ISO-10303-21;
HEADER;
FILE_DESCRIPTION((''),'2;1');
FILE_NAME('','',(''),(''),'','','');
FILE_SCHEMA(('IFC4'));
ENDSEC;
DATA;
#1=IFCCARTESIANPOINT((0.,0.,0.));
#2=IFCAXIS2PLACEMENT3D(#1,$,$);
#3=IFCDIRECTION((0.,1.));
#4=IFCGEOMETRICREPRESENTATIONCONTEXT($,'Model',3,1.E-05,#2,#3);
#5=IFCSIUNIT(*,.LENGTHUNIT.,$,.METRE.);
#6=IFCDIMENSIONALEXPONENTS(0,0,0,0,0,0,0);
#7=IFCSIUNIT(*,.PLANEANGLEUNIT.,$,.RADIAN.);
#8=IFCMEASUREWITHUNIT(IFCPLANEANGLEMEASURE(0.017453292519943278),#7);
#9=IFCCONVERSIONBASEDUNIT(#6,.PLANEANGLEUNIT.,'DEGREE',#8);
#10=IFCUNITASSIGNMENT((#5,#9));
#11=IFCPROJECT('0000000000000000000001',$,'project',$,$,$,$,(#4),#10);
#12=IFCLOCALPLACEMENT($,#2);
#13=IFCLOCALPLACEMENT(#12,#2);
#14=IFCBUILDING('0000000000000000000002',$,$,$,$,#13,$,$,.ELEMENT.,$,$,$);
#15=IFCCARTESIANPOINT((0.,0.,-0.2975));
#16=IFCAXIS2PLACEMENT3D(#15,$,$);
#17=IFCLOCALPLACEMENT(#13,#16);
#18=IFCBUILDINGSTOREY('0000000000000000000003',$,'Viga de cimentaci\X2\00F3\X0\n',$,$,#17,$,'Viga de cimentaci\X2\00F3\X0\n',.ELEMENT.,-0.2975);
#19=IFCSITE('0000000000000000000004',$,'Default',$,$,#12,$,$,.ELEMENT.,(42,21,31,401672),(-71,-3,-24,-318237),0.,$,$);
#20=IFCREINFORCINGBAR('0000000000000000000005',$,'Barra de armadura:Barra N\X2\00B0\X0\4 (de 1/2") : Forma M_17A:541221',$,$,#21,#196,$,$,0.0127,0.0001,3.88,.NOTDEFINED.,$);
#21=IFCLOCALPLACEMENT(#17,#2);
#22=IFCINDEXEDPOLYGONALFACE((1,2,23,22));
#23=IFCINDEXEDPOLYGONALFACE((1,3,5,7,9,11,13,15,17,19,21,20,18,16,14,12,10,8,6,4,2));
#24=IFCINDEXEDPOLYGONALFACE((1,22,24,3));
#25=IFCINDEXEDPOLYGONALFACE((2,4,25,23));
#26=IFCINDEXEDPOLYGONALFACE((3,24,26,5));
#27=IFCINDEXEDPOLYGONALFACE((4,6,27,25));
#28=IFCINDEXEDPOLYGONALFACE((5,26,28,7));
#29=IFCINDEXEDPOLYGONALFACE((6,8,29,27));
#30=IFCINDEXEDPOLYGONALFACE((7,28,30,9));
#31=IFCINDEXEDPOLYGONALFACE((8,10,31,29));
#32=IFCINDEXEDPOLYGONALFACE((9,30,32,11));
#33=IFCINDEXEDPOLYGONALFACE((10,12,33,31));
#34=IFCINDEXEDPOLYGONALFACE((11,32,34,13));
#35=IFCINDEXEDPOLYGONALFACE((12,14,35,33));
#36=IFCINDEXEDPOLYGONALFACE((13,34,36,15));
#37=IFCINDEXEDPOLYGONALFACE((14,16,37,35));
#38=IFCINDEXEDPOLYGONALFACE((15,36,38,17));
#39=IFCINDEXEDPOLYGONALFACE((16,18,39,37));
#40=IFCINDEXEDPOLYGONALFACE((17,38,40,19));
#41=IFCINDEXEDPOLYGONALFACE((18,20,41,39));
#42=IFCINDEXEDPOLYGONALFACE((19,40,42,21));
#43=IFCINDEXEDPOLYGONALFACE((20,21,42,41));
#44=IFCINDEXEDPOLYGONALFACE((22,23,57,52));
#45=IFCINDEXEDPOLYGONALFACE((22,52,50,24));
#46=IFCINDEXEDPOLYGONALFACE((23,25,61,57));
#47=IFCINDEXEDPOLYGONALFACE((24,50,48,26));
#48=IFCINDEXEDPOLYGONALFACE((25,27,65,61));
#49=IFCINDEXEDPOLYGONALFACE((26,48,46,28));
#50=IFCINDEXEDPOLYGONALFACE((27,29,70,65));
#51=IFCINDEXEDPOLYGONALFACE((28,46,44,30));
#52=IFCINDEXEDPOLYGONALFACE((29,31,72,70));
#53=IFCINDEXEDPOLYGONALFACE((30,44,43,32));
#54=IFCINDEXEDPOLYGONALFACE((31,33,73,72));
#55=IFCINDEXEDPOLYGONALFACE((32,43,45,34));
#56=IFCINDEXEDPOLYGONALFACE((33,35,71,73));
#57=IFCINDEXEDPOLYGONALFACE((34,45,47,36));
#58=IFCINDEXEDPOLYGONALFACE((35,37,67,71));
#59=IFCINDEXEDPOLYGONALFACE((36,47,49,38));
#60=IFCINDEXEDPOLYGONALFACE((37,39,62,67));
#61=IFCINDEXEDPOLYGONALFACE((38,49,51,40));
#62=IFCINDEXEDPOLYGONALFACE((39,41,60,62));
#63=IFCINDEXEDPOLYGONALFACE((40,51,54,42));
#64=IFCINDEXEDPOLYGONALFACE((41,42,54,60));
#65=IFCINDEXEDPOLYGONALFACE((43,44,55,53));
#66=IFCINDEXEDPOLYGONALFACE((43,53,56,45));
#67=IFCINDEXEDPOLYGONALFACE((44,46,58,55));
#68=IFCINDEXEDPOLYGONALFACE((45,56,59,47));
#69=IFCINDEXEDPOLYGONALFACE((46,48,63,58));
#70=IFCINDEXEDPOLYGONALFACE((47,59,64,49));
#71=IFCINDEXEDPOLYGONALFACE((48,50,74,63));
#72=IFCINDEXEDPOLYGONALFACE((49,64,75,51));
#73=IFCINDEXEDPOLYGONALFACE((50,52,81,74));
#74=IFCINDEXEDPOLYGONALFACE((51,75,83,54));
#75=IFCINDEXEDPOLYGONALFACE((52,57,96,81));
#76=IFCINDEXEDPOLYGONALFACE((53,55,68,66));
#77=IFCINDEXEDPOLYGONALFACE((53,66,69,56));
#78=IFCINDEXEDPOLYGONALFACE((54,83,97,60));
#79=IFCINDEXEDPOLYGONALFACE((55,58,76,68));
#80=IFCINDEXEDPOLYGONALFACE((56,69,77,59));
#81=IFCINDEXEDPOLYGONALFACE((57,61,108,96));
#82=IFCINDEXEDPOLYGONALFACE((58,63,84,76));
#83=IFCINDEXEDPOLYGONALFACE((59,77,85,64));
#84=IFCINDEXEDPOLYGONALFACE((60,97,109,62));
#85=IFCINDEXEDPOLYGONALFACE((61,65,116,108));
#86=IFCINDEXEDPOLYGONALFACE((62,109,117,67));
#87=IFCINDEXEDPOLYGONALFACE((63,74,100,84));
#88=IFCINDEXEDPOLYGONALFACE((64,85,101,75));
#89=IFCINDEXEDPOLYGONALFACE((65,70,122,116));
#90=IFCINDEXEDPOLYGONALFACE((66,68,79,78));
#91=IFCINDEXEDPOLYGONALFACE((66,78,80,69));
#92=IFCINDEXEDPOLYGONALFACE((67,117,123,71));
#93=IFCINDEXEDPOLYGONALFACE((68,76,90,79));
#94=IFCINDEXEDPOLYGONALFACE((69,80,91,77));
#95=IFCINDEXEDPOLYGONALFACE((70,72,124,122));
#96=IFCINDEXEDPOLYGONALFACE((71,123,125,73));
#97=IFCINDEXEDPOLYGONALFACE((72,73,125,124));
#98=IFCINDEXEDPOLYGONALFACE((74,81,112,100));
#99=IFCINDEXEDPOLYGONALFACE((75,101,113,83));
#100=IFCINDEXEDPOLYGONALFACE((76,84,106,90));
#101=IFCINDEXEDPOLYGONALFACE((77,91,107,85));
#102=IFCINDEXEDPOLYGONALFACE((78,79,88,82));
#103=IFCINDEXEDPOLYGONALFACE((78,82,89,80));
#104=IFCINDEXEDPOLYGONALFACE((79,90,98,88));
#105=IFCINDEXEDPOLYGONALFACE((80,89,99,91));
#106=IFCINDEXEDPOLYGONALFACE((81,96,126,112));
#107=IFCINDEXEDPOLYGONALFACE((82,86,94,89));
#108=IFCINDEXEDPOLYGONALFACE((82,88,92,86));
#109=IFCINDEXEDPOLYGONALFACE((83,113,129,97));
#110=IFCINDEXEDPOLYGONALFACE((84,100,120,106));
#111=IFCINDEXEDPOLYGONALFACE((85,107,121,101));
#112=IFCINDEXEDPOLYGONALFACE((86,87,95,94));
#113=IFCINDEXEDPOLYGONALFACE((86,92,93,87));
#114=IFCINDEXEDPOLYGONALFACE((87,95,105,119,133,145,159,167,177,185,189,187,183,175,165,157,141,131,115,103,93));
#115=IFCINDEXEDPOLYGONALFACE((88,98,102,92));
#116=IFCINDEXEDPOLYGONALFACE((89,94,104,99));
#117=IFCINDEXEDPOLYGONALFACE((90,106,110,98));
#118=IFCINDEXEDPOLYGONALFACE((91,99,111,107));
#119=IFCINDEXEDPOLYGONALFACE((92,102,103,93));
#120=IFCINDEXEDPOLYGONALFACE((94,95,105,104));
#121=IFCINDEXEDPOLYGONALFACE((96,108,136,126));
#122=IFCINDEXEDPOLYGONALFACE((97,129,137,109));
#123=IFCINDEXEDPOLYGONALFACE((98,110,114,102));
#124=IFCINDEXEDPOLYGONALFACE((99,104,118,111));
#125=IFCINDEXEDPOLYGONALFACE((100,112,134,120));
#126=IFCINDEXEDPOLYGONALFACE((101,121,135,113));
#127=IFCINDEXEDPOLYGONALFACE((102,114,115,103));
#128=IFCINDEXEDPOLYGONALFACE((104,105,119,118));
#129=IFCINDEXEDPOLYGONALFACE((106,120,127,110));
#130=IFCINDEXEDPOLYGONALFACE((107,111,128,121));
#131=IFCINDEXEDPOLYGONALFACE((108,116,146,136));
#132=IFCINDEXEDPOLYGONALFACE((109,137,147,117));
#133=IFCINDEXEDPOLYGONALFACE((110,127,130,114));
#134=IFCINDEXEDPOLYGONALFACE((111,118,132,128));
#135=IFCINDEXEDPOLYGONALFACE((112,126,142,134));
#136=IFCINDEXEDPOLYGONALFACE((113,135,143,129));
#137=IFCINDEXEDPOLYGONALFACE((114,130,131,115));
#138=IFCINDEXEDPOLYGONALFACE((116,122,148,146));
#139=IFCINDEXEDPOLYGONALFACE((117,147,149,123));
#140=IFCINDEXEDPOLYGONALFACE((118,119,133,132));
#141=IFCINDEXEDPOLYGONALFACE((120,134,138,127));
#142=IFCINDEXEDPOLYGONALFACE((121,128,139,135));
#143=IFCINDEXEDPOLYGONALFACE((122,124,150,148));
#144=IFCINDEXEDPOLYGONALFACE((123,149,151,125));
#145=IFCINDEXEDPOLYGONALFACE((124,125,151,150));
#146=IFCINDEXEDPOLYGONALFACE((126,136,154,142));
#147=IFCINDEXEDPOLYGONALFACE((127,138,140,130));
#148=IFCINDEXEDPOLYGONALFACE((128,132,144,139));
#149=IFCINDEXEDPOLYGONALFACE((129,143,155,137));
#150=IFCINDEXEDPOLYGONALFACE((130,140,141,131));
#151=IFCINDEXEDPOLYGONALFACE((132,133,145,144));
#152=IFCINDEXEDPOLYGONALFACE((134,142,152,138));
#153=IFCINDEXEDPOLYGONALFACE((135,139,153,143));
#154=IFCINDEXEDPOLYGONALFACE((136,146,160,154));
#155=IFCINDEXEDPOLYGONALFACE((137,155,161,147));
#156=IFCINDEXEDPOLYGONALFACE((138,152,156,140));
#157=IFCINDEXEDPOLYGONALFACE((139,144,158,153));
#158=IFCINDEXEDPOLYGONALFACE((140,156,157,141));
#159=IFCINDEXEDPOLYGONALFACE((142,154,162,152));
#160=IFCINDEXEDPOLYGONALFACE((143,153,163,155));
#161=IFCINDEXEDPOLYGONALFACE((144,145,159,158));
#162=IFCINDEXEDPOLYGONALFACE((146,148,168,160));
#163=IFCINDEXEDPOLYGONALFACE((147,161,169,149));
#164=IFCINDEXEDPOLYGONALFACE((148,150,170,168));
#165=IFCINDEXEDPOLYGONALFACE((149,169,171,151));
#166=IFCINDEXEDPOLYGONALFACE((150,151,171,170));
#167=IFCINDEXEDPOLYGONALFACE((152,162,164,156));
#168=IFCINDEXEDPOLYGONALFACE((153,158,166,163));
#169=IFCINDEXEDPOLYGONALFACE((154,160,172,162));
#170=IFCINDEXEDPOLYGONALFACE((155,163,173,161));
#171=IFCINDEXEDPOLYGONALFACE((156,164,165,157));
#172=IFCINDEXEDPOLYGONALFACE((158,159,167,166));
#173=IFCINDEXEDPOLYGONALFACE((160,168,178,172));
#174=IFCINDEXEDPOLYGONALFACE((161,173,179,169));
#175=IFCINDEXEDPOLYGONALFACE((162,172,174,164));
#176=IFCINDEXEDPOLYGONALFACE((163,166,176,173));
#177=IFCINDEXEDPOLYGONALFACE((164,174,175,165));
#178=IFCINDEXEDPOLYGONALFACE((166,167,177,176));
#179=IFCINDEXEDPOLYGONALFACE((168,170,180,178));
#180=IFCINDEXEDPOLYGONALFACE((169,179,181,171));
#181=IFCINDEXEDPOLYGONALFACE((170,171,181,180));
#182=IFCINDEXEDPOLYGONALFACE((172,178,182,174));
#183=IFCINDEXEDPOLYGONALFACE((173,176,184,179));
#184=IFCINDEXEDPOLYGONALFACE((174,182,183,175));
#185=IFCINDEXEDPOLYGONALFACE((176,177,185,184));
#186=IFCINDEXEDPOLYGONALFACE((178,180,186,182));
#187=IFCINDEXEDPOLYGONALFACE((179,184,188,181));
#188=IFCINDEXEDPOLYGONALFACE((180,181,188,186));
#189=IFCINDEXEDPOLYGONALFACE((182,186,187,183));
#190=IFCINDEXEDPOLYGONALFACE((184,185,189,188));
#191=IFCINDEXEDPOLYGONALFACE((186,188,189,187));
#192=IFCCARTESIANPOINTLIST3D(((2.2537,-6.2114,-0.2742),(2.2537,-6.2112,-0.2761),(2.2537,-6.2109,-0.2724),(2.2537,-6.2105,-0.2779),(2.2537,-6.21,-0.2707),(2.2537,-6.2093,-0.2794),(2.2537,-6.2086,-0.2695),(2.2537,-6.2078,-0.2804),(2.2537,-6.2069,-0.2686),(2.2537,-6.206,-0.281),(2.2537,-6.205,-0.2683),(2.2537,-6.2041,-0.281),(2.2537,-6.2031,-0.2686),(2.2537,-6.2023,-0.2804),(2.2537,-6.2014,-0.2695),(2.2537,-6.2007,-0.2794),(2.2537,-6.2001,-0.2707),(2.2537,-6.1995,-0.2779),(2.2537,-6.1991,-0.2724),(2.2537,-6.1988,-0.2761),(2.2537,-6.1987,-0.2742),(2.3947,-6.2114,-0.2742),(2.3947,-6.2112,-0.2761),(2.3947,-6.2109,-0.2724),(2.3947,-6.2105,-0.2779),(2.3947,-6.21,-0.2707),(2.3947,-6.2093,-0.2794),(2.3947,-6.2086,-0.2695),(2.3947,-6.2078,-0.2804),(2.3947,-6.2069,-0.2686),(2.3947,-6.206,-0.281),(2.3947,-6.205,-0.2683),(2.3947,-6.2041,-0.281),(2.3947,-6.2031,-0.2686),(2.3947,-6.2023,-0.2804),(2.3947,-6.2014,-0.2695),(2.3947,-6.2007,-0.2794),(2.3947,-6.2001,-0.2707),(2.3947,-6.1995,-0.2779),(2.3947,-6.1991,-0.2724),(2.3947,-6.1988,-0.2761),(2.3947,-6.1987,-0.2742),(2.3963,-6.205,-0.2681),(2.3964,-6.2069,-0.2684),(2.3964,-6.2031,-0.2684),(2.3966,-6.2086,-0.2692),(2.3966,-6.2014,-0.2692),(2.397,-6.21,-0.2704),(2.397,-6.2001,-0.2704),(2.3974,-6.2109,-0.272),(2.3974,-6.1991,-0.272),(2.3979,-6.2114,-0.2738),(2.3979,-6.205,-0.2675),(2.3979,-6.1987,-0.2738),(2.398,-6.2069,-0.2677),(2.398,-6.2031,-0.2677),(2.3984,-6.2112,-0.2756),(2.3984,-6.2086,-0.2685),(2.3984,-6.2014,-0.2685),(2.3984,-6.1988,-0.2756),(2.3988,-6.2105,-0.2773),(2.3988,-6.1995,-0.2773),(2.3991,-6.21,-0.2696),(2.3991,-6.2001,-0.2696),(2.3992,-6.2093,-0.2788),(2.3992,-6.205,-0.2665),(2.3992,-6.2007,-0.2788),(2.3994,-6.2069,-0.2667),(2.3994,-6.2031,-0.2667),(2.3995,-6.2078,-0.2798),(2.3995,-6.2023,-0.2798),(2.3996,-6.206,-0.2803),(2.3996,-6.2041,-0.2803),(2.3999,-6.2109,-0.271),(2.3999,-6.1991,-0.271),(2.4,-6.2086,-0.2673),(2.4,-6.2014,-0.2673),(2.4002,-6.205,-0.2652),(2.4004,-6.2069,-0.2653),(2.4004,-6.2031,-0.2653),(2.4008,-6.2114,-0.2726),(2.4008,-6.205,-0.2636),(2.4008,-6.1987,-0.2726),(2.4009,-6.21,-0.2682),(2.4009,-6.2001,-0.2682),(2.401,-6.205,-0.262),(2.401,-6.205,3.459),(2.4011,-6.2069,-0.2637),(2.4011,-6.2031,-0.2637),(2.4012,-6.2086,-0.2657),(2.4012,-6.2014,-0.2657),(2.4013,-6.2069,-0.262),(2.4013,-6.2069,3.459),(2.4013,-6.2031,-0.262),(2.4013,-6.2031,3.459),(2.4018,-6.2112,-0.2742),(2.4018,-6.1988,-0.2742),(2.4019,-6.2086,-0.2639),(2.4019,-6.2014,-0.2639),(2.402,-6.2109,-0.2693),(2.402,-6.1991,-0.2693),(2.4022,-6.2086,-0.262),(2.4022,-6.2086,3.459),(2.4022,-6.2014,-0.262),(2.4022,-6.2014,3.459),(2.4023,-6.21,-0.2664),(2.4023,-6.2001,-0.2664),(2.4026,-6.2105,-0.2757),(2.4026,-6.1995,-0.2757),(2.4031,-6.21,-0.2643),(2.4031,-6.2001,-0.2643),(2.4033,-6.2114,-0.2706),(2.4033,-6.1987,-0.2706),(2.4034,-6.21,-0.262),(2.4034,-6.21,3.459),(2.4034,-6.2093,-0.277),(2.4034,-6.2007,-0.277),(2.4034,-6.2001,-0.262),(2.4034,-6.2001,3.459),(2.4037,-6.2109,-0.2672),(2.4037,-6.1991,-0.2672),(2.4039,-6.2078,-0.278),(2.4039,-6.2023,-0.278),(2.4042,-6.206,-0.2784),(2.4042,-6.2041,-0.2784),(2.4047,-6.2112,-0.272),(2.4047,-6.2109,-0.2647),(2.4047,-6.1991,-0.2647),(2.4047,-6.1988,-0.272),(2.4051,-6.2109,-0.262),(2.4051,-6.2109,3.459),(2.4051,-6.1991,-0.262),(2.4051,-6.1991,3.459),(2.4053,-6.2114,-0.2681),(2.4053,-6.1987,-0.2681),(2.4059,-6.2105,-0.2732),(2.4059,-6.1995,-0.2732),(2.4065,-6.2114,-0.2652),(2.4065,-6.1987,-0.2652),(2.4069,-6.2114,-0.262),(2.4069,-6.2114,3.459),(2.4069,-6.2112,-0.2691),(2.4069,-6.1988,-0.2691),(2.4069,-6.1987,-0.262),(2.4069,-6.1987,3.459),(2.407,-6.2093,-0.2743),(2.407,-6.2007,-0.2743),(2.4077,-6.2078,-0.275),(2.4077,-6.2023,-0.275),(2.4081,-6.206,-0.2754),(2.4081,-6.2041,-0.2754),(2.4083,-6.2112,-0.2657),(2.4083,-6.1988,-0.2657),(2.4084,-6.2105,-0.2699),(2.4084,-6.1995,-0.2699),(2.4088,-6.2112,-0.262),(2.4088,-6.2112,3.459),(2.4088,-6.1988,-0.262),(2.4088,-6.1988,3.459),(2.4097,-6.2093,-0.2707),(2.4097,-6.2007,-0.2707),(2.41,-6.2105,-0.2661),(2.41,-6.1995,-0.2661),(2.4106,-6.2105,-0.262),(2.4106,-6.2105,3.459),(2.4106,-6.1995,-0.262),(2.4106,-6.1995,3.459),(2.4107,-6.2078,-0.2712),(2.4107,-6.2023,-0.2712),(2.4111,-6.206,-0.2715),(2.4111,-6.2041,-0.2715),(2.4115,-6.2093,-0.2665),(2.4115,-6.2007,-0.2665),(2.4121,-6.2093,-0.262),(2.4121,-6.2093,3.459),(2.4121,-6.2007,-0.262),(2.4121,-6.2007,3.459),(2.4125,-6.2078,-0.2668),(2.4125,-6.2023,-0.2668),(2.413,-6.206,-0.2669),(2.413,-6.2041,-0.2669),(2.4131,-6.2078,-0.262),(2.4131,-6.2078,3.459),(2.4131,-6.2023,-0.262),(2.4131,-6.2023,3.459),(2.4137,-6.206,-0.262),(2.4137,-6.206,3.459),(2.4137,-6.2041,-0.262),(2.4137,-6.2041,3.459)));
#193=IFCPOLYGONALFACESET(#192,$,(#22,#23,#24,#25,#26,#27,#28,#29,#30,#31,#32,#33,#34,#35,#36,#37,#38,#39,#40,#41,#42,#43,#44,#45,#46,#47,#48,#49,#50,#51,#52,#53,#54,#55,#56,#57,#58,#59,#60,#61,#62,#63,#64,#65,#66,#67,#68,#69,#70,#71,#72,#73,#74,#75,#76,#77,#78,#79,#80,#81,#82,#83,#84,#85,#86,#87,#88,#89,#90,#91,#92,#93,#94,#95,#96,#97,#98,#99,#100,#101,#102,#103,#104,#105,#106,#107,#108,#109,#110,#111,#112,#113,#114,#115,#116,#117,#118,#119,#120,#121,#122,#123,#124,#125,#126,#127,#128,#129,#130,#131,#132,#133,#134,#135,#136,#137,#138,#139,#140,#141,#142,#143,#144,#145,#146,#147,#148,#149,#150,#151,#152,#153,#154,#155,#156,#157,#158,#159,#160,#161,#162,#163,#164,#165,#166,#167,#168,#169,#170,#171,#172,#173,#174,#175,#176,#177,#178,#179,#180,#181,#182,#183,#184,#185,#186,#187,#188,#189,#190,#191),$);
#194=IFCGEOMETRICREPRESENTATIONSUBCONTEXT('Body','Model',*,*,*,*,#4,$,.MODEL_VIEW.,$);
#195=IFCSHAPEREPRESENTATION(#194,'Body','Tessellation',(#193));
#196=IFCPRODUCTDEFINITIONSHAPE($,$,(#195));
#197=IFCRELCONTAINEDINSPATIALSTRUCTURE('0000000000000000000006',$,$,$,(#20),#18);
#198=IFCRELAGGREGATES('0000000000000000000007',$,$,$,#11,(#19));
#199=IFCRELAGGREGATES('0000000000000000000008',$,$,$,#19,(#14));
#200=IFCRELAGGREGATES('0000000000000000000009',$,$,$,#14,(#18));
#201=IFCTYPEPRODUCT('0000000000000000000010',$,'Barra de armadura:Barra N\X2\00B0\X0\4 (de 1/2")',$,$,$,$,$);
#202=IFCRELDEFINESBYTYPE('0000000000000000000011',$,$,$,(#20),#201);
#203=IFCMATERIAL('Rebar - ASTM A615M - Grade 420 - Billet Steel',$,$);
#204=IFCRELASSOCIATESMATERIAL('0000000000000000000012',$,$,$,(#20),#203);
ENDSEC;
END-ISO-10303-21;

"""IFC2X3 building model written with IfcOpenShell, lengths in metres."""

from ifc_helpers import new_model, entity, si_unit, converted_unit, direction, frame, origin, place, context, subcontext, project, spatial, material, type_object, element, save


model = new_model("IFC2X3")

# Units and contexts
model_context = context("Model", 3, precision=1e-05, world=origin(), true_north=direction((0.0, 1.0)))
body_context = subcontext(model_context, "Body", "Model", "MODEL_VIEW")
ifc_project = project(units=[si_unit("LENGTHUNIT", "METRE"), converted_unit("PLANEANGLEUNIT", "DEGREE", entity("IfcPlaneAngleMeasure", 0.017453292519943278), si_unit("PLANEANGLEUNIT", "RADIAN"), dimensions=[0, 0, 0, 0, 0, 0, 0])], contexts=[model_context])

# Site, building, storey
site_placement = place(None, origin())
site = spatial("IfcSite", under=ifc_project, at=site_placement, Name="Default", CompositionType="ELEMENT", RefLatitude=(42, 21, 31, 401672), RefLongitude=(-71, -3, -24, -318237), RefElevation=0.0)
building_placement = place(site_placement, origin())
building = spatial("IfcBuilding", under=site, at=building_placement, CompositionType="ELEMENT")
storey_placement = place(building_placement, frame((0.0, 0.0, -0.2975)))
storey = spatial("IfcBuildingStorey", under=building, at=storey_placement, Name="Viga de cimentación", LongName="Viga de cimentación", CompositionType="ELEMENT", Elevation=-0.2975)

# Reinforcing bar
ifc_material_1 = material(Name="Rebar - ASTM A615M - Grade 420 - Billet Steel")
type_product_1 = type_object("IfcTypeProduct", Name="Barra de armadura:Barra N°4 (de 1/2\")")
reinforcing_bar_1_placement = place(storey_placement, origin())
element("IfcReinforcingBar", 1, at=reinforcing_bar_1_placement, inside=storey, type_object=type_product_1, material=ifc_material_1, Name="Barra de armadura:Barra N°4 (de 1/2\") : Forma M_17A:541221", BarLength=3.88, BarRole="NOTDEFINED", CrossSectionArea=0.0001, NominalDiameter=0.0127, context=body_context, shape_type="AdvancedSweptSolid", body=[
    entity("IfcSweptDiskSolid", entity("IfcCompositeCurve", [entity("IfcCompositeCurveSegment", "CONTINUOUS", True, entity("IfcPolyline", [entity("IfcCartesianPoint", [2.4074, -6.205, 3.459]), entity("IfcCartesianPoint", [2.4074, -6.205, -0.262])])), entity("IfcCompositeCurveSegment", "CONTINUOUS", True, entity("IfcTrimmedCurve", entity("IfcCircle", entity("IfcAxis2Placement3D", entity("IfcCartesianPoint", [2.3947, -6.205, -0.262]), entity("IfcDirection", [0.0, 1.0, 0.0]), entity("IfcDirection", [0.0, 0.0, -1.0])), 0.0127), [entity("IfcParameterValue", 270.0)], [entity("IfcParameterValue", 360.0)], True, "PARAMETER")), entity("IfcCompositeCurveSegment", "CONTINUOUS", True, entity("IfcPolyline", [entity("IfcCartesianPoint", [2.3947, -6.205, -0.2747]), entity("IfcCartesianPoint", [2.2537, -6.205, -0.2747])]))], False), 0.0063, None, 0.0, 92.0),
])

save(model, "model.ifc")
